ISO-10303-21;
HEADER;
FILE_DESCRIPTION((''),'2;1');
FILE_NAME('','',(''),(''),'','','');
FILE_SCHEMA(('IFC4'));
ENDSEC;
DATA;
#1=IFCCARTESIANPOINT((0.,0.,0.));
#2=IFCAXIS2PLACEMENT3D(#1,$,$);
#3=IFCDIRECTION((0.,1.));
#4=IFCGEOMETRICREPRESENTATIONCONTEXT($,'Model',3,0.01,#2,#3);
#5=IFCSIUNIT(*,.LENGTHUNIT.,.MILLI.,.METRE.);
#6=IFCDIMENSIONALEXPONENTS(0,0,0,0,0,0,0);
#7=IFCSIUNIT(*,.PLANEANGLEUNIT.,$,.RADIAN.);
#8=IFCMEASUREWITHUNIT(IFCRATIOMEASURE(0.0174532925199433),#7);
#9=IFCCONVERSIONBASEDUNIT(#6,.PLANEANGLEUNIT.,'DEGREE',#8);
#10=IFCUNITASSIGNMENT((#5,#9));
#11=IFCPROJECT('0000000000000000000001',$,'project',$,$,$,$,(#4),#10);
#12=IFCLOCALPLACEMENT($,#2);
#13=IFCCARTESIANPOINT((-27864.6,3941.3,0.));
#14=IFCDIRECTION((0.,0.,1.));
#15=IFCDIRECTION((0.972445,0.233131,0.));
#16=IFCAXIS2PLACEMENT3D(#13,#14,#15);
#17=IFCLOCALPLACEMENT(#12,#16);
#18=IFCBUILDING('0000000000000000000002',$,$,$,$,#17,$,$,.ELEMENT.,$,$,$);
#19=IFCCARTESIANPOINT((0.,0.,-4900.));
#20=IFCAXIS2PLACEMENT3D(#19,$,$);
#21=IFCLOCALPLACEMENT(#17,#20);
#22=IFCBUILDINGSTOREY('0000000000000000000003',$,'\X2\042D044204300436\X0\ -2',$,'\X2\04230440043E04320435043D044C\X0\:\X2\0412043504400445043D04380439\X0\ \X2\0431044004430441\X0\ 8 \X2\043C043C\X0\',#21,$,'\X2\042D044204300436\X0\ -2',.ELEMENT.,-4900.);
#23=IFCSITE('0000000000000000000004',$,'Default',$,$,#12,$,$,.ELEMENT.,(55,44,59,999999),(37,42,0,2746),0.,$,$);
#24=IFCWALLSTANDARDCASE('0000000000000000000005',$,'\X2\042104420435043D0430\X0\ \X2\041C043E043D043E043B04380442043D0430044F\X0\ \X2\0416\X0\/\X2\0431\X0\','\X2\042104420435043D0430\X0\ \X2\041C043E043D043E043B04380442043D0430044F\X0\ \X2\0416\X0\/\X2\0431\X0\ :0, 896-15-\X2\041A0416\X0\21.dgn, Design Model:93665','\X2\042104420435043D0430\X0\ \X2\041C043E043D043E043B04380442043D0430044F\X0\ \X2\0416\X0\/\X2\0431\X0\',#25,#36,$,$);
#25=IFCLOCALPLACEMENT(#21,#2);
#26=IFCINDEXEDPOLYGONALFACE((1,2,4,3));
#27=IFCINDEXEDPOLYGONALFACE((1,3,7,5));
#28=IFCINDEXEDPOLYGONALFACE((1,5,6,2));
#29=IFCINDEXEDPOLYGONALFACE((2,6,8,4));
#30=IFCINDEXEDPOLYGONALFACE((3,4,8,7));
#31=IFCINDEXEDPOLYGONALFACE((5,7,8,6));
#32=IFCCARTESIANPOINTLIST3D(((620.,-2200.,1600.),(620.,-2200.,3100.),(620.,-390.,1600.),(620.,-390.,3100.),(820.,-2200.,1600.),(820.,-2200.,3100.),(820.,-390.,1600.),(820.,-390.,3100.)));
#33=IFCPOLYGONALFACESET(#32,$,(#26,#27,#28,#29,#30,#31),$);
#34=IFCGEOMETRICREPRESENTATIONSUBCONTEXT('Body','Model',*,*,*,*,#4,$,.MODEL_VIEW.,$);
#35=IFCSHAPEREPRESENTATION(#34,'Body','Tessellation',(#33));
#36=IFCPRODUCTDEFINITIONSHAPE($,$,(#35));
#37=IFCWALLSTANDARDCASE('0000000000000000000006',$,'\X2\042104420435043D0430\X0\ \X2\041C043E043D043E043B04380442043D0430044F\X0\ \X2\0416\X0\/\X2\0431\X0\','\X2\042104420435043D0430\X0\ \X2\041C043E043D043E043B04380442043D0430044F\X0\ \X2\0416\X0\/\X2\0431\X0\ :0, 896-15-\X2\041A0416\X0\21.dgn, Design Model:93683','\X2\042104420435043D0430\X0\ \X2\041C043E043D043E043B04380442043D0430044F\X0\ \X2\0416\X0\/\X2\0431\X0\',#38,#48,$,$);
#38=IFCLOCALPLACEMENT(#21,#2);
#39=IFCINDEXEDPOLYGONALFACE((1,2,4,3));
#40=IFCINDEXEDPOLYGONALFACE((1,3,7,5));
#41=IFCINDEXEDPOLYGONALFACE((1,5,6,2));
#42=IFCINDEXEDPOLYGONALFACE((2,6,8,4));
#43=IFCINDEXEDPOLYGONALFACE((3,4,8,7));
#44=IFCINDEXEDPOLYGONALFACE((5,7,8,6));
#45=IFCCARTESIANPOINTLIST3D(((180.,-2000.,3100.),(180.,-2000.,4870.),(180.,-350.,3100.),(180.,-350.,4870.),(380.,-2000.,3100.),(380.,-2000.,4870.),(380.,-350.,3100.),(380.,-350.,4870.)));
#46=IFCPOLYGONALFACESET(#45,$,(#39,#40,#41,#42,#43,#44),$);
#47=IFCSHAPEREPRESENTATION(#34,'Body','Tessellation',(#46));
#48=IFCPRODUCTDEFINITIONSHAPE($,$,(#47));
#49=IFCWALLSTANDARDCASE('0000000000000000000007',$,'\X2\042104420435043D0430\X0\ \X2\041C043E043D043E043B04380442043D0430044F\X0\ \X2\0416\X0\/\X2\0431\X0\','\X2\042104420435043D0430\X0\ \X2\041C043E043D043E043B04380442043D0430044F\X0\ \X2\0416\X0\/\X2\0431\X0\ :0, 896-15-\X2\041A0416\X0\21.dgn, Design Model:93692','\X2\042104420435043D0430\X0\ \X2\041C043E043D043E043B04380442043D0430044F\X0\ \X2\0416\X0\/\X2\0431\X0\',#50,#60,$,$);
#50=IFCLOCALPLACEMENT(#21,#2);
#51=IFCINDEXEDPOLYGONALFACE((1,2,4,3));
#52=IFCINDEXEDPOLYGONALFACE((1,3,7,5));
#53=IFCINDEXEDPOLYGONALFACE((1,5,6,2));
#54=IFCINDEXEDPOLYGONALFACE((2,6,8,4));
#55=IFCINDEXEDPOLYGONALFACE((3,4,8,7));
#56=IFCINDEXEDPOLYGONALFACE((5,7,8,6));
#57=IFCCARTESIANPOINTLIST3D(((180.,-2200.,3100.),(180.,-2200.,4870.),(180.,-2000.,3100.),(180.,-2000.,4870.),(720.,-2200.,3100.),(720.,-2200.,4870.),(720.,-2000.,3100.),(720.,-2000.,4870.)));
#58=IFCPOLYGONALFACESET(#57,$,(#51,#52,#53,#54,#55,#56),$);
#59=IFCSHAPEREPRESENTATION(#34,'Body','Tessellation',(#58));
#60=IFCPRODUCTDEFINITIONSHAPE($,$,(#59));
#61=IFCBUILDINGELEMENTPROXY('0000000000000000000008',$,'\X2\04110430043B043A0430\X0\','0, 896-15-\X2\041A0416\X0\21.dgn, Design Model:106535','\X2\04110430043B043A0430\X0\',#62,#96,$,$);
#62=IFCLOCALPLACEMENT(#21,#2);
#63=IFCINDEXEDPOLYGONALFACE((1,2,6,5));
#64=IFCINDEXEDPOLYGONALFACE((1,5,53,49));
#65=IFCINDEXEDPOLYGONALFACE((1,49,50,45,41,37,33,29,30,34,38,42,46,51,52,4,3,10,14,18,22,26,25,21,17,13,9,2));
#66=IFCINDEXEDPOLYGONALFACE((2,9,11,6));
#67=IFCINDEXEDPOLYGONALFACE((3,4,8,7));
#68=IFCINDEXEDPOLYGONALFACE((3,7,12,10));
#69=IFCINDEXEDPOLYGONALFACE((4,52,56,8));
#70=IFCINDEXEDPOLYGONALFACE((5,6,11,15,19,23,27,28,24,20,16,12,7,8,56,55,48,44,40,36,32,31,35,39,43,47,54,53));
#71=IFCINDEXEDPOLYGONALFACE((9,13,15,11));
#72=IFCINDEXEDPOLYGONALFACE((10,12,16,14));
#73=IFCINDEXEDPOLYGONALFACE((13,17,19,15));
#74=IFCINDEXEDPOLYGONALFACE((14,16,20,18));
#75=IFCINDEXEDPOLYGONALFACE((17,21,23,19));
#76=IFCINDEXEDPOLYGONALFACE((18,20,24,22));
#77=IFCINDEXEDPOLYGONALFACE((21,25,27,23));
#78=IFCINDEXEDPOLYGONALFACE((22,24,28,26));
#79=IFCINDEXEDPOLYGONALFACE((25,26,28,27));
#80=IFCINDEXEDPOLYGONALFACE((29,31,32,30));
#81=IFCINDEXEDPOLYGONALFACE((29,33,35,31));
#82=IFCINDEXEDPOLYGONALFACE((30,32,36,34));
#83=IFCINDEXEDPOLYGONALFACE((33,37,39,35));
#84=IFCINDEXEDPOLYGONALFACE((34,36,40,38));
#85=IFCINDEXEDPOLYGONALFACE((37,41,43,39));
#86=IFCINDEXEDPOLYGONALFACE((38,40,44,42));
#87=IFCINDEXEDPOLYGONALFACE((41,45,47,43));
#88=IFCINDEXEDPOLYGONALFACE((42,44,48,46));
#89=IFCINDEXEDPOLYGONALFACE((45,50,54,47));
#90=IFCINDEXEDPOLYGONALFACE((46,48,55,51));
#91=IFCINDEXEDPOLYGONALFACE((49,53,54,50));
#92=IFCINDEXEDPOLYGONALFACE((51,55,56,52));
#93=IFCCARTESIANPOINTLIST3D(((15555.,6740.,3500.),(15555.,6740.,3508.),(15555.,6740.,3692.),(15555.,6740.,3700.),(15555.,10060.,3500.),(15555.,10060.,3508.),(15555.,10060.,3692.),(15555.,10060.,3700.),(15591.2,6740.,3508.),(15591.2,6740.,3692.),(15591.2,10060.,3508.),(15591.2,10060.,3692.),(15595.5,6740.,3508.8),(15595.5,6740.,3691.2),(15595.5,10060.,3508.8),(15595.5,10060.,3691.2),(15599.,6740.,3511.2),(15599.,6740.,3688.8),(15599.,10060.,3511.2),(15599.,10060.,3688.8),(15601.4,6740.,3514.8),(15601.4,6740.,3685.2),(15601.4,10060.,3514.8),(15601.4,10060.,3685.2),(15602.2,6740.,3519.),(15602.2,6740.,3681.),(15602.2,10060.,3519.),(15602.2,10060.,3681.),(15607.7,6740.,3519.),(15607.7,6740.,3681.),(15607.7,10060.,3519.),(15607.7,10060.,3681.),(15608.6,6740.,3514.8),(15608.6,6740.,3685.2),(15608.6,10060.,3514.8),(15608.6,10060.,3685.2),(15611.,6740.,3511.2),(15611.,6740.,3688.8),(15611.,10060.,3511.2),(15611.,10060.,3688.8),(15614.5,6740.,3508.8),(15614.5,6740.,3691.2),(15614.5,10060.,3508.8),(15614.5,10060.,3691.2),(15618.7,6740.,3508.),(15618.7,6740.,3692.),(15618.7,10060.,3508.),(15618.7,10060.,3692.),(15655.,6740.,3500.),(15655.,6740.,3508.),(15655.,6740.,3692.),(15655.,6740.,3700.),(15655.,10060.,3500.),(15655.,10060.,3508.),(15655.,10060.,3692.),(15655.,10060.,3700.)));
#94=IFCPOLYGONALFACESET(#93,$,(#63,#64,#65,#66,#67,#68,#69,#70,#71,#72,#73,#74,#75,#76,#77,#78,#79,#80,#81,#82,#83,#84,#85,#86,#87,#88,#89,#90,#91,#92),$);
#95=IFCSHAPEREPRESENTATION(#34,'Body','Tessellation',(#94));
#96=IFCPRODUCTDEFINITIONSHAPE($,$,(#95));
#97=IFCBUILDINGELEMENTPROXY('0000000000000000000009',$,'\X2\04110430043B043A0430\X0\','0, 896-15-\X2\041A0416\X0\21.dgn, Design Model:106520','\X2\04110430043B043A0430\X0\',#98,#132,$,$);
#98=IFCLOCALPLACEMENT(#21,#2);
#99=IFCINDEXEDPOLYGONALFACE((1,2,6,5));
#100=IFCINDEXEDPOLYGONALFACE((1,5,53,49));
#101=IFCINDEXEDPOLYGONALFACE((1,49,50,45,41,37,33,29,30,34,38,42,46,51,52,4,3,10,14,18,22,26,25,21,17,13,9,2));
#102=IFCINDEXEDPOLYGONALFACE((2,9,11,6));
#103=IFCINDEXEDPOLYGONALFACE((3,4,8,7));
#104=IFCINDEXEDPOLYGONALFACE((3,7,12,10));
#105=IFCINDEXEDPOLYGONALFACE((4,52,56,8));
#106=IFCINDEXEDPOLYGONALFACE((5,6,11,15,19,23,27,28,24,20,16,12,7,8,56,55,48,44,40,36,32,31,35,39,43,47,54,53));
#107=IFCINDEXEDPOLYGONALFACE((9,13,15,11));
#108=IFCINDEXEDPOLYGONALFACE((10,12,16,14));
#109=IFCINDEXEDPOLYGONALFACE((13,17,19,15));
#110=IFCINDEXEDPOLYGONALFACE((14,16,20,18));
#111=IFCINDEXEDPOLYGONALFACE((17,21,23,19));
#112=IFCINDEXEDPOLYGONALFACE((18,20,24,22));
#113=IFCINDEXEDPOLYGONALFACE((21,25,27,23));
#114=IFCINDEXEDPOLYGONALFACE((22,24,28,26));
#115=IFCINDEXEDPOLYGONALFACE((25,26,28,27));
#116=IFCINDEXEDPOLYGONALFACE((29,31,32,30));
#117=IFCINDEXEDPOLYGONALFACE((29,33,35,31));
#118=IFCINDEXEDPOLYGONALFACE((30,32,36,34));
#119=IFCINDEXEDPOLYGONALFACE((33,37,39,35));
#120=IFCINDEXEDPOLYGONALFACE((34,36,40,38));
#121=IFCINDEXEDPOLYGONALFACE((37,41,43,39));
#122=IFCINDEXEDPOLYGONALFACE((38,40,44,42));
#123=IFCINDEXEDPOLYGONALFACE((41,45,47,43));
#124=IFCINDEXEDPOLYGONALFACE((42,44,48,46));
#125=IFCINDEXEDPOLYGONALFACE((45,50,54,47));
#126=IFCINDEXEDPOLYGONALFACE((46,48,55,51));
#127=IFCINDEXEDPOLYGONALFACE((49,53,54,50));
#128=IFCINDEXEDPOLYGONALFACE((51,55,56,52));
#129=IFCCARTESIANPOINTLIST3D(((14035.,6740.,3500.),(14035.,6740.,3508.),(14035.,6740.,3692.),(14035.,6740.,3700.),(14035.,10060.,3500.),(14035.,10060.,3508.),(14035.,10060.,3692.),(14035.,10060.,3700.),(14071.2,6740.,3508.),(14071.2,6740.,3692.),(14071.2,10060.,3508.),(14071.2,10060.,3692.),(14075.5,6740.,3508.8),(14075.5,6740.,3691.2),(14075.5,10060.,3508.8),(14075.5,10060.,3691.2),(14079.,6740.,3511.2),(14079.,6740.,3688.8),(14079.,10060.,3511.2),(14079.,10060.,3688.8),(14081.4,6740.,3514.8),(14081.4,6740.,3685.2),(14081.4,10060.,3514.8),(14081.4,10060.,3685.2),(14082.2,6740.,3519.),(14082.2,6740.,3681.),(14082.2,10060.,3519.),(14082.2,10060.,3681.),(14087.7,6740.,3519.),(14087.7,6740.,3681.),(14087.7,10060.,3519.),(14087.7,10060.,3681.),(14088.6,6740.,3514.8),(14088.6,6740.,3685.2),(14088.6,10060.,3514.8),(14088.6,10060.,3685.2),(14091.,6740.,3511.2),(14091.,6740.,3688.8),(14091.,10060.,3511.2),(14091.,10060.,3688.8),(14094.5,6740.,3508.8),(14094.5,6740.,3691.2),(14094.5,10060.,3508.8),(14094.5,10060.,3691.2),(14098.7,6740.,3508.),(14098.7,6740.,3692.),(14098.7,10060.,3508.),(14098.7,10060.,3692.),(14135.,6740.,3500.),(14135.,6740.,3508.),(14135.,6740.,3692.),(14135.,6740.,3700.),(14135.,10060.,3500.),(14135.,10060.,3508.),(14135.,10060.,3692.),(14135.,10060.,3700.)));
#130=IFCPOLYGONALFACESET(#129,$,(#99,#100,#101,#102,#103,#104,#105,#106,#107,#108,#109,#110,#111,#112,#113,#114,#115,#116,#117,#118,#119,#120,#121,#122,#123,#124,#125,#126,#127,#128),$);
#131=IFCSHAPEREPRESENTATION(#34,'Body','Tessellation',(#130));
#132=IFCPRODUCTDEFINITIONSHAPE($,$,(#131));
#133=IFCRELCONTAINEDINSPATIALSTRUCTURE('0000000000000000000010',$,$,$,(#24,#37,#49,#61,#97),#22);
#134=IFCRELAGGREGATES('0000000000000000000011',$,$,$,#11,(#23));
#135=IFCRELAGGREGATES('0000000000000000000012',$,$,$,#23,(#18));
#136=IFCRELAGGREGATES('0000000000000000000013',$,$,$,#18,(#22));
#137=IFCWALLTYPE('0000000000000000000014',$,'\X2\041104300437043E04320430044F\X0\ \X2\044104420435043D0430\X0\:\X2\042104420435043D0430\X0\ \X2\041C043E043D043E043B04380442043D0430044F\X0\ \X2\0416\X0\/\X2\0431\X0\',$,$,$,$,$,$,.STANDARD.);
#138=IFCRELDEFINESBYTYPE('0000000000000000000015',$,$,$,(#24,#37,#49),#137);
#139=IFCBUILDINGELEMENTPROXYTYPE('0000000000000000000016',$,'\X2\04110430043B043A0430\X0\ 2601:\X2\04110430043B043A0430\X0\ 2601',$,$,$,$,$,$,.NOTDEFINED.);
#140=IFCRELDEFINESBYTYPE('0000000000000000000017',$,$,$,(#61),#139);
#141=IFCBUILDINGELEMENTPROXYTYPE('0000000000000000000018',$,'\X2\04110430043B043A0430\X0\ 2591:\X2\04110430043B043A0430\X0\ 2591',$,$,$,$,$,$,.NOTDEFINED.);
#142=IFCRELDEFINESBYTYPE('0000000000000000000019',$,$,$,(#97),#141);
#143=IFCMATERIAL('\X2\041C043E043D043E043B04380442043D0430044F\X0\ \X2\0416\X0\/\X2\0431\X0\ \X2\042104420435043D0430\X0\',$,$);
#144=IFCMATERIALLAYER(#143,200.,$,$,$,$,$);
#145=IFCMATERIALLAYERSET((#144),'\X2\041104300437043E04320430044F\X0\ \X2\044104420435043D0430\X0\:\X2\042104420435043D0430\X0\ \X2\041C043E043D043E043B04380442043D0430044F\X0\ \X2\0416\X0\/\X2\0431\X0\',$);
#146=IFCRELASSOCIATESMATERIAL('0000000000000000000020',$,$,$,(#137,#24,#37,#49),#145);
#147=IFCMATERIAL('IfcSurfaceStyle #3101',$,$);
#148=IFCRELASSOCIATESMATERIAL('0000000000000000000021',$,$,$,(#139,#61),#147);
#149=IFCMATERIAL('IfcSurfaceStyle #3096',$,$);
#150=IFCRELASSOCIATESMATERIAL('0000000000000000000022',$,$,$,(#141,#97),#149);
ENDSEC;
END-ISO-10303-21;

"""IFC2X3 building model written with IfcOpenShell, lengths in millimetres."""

from ifc_helpers import new_model, entity, si_unit, converted_unit, direction, frame, frame_2d, origin, place, context, subcontext, project, spatial, polyline, rectangle, outline, extrude, source, transform, mapped, material, layer, layer_set, layer_usage, type_object, type_shapes, element, save


model = new_model("IFC2X3")

# Units and contexts
model_context = context("Model", 3, precision=0.01, world=origin(), true_north=direction((0.0, 1.0)))
body_context = subcontext(model_context, "Body", "Model", "MODEL_VIEW")
ifc_project = project(units=[si_unit("LENGTHUNIT", "METRE", prefix="MILLI"), converted_unit("PLANEANGLEUNIT", "DEGREE", entity("IfcRatioMeasure", 0.0174532925199433), si_unit("PLANEANGLEUNIT", "RADIAN"), dimensions=[0, 0, 0, 0, 0, 0, 0])], contexts=[model_context])

# Site, building, storey
site_placement = place(None, origin())
site = spatial("IfcSite", under=ifc_project, at=site_placement, Name="Default", CompositionType="ELEMENT", RefLatitude=(55, 44, 59, 999999), RefLongitude=(37, 42, 0, 2746), RefElevation=0.0)
building_placement = place(site_placement, frame((-27864.6, 3941.3, 0.0), z_axis=(0.0, 0.0, 1.0), x_axis=(0.972445, 0.233131, 0.0)))
building = spatial("IfcBuilding", under=site, at=building_placement, CompositionType="ELEMENT")
storey_placement = place(building_placement, frame((0.0, 0.0, -4900.0)))
storey = spatial("IfcBuildingStorey", under=building, at=storey_placement, Name="Этаж -2", ObjectType="Уровень:Верхний брус 8 мм", LongName="Этаж -2", CompositionType="ELEMENT", Elevation=-4900.0)

# Walls
ifc_material_1 = material(Name="Монолитная Ж/б Стена")
ifc_layer = layer(ifc_material_1, 200.0)
ifc_layer_set = layer_set([ifc_layer], Name="Базовая стена:Стена Монолитная Ж/б")
ifc_layer_usage_1 = layer_usage(ifc_layer_set, "AXIS2", "NEGATIVE", 100.0)
wall_type = type_object("IfcWallType", Name="Базовая стена:Стена Монолитная Ж/б", PredefinedType="STANDARD", material=ifc_layer_set)
wall_1_placement = place(storey_placement, frame((720.0, -2200.0, 1600.0), z_axis=(0.0, 0.0, 1.0), x_axis=(0.0, 1.0, 0.0)))
element("IfcWallStandardCase", 1, at=wall_1_placement, inside=storey, type_object=wall_type, material=ifc_layer_usage_1, Name="Стена Монолитная Ж/б", Description="Стена Монолитная Ж/б :0, 896-15-КЖ21.dgn, Design Model:93665", ObjectType="Стена Монолитная Ж/б", context=body_context, shape_type="SweptSolid", body=[
    extrude(rectangle(XDim=1810.0, YDim=200.0, at=frame_2d((905.0, 0.0), x_axis=(-1.0, 0.0))), origin(), (0.0, 0.0, 1.0), 1500.0),
])
ifc_layer_usage_2 = layer_usage(ifc_layer_set, "AXIS2", "NEGATIVE", 100.0)
wall_2_placement = place(storey_placement, frame((280.0, -2000.0, 3100.0), z_axis=(0.0, 0.0, 1.0), x_axis=(0.0, 1.0, 0.0)))
element("IfcWallStandardCase", 2, at=wall_2_placement, inside=storey, type_object=wall_type, material=ifc_layer_usage_2, Name="Стена Монолитная Ж/б", Description="Стена Монолитная Ж/б :0, 896-15-КЖ21.dgn, Design Model:93683", ObjectType="Стена Монолитная Ж/б", context=body_context, shape_type="SweptSolid", body=[
    extrude(rectangle(XDim=1650.0, YDim=200.0, at=frame_2d((825.0, 0.0), x_axis=(-1.0, 0.0))), origin(), (0.0, 0.0, 1.0), 1770.0),
])
ifc_layer_usage_3 = layer_usage(ifc_layer_set, "AXIS2", "NEGATIVE", 100.0)
wall_3_placement = place(storey_placement, frame((720.0, -2100.0, 3100.0), z_axis=(0.0, 0.0, 1.0), x_axis=(-1.0, 0.0, 0.0)))
element("IfcWallStandardCase", 3, at=wall_3_placement, inside=storey, type_object=wall_type, material=ifc_layer_usage_3, Name="Стена Монолитная Ж/б", Description="Стена Монолитная Ж/б :0, 896-15-КЖ21.dgn, Design Model:93692", ObjectType="Стена Монолитная Ж/б", context=body_context, shape_type="SweptSolid", body=[
    extrude(rectangle(XDim=540.0, YDim=200.0, at=frame_2d((270.0, 0.0), x_axis=(-1.0, 0.0))), origin(), (0.0, 0.0, 1.0), 1770.0),
])

# Building element proxies
ifc_material_2 = material(Name="IfcSurfaceStyle #3101")
building_element_proxy_type_1 = type_object("IfcBuildingElementProxyType", Name="Балка 2601:Балка 2601", PredefinedType="NOTDEFINED", material=ifc_material_2)
shared_shape_1 = source(origin(), body_context, "Body", "SweptSolid", [
    extrude(outline(polyline([(92.0, -50.0), (100.0, -50.0), (100.0, 50.0), (92.0, 50.0), (92.0, 13.8), (91.2, 9.5), (88.8, 6.0), (85.2, 3.6), (81.0, 2.8), (-81.0, 2.8), (-85.2, 3.6), (-88.8, 6.0), (-91.2, 9.5), (-92.0, 13.8), (-92.0, 50.0), (-100.0, 50.0), (-100.0, -50.0), (-92.0, -50.0), (-92.0, -13.7), (-91.2, -9.5), (-88.8, -6.0), (-85.2, -3.6), (-81.0, -2.7), (81.0, -2.7), (85.2, -3.6), (88.8, -6.0), (91.2, -9.5), (92.0, -13.7), (92.0, -50.0)])), frame((15605.0, 6740.0, -1300.0), z_axis=(0.0, 1.0, 0.0), x_axis=(0.0, 0.0, -1.0)), (0.0, 0.0, 1.0), 3320.0),
])
type_shapes(building_element_proxy_type_1, [shared_shape_1])
proxy_1_placement = place(storey_placement, frame((0.0, 0.0, 4900.0)))
element("IfcBuildingElementProxy", 4, at=proxy_1_placement, inside=storey, type_object=building_element_proxy_type_1, material=ifc_material_2, Name="Балка", Description="0, 896-15-КЖ21.dgn, Design Model:106535", ObjectType="Балка", context=body_context, shape_type="MappedRepresentation", body=[
    mapped(shared_shape_1, transform((0.0, 0.0, 0.0), scale=1.0)),
])
ifc_material_3 = material(Name="IfcSurfaceStyle #3096")
building_element_proxy_type_2 = type_object("IfcBuildingElementProxyType", Name="Балка 2591:Балка 2591", PredefinedType="NOTDEFINED", material=ifc_material_3)
shared_shape_2 = source(origin(), body_context, "Body", "SweptSolid", [
    extrude(outline(polyline([(92.0, -50.0), (100.0, -50.0), (100.0, 50.0), (92.0, 50.0), (92.0, 13.8), (91.2, 9.5), (88.8, 6.0), (85.2, 3.6), (81.0, 2.8), (-81.0, 2.8), (-85.2, 3.6), (-88.8, 6.0), (-91.2, 9.5), (-92.0, 13.8), (-92.0, 50.0), (-100.0, 50.0), (-100.0, -50.0), (-92.0, -50.0), (-92.0, -13.7), (-91.2, -9.5), (-88.8, -6.0), (-85.2, -3.6), (-81.0, -2.7), (81.0, -2.7), (85.2, -3.6), (88.8, -6.0), (91.2, -9.5), (92.0, -13.7), (92.0, -50.0)])), frame((14085.0, 6740.0, -1300.0), z_axis=(0.0, 1.0, 0.0), x_axis=(0.0, 0.0, -1.0)), (0.0, 0.0, 1.0), 3320.0),
])
type_shapes(building_element_proxy_type_2, [shared_shape_2])
proxy_2_placement = place(storey_placement, frame((0.0, 0.0, 4900.0)))
element("IfcBuildingElementProxy", 5, at=proxy_2_placement, inside=storey, type_object=building_element_proxy_type_2, material=ifc_material_3, Name="Балка", Description="0, 896-15-КЖ21.dgn, Design Model:106520", ObjectType="Балка", context=body_context, shape_type="MappedRepresentation", body=[
    mapped(shared_shape_2, transform((0.0, 0.0, 0.0), scale=1.0)),
])

save(model, "model.ifc")
